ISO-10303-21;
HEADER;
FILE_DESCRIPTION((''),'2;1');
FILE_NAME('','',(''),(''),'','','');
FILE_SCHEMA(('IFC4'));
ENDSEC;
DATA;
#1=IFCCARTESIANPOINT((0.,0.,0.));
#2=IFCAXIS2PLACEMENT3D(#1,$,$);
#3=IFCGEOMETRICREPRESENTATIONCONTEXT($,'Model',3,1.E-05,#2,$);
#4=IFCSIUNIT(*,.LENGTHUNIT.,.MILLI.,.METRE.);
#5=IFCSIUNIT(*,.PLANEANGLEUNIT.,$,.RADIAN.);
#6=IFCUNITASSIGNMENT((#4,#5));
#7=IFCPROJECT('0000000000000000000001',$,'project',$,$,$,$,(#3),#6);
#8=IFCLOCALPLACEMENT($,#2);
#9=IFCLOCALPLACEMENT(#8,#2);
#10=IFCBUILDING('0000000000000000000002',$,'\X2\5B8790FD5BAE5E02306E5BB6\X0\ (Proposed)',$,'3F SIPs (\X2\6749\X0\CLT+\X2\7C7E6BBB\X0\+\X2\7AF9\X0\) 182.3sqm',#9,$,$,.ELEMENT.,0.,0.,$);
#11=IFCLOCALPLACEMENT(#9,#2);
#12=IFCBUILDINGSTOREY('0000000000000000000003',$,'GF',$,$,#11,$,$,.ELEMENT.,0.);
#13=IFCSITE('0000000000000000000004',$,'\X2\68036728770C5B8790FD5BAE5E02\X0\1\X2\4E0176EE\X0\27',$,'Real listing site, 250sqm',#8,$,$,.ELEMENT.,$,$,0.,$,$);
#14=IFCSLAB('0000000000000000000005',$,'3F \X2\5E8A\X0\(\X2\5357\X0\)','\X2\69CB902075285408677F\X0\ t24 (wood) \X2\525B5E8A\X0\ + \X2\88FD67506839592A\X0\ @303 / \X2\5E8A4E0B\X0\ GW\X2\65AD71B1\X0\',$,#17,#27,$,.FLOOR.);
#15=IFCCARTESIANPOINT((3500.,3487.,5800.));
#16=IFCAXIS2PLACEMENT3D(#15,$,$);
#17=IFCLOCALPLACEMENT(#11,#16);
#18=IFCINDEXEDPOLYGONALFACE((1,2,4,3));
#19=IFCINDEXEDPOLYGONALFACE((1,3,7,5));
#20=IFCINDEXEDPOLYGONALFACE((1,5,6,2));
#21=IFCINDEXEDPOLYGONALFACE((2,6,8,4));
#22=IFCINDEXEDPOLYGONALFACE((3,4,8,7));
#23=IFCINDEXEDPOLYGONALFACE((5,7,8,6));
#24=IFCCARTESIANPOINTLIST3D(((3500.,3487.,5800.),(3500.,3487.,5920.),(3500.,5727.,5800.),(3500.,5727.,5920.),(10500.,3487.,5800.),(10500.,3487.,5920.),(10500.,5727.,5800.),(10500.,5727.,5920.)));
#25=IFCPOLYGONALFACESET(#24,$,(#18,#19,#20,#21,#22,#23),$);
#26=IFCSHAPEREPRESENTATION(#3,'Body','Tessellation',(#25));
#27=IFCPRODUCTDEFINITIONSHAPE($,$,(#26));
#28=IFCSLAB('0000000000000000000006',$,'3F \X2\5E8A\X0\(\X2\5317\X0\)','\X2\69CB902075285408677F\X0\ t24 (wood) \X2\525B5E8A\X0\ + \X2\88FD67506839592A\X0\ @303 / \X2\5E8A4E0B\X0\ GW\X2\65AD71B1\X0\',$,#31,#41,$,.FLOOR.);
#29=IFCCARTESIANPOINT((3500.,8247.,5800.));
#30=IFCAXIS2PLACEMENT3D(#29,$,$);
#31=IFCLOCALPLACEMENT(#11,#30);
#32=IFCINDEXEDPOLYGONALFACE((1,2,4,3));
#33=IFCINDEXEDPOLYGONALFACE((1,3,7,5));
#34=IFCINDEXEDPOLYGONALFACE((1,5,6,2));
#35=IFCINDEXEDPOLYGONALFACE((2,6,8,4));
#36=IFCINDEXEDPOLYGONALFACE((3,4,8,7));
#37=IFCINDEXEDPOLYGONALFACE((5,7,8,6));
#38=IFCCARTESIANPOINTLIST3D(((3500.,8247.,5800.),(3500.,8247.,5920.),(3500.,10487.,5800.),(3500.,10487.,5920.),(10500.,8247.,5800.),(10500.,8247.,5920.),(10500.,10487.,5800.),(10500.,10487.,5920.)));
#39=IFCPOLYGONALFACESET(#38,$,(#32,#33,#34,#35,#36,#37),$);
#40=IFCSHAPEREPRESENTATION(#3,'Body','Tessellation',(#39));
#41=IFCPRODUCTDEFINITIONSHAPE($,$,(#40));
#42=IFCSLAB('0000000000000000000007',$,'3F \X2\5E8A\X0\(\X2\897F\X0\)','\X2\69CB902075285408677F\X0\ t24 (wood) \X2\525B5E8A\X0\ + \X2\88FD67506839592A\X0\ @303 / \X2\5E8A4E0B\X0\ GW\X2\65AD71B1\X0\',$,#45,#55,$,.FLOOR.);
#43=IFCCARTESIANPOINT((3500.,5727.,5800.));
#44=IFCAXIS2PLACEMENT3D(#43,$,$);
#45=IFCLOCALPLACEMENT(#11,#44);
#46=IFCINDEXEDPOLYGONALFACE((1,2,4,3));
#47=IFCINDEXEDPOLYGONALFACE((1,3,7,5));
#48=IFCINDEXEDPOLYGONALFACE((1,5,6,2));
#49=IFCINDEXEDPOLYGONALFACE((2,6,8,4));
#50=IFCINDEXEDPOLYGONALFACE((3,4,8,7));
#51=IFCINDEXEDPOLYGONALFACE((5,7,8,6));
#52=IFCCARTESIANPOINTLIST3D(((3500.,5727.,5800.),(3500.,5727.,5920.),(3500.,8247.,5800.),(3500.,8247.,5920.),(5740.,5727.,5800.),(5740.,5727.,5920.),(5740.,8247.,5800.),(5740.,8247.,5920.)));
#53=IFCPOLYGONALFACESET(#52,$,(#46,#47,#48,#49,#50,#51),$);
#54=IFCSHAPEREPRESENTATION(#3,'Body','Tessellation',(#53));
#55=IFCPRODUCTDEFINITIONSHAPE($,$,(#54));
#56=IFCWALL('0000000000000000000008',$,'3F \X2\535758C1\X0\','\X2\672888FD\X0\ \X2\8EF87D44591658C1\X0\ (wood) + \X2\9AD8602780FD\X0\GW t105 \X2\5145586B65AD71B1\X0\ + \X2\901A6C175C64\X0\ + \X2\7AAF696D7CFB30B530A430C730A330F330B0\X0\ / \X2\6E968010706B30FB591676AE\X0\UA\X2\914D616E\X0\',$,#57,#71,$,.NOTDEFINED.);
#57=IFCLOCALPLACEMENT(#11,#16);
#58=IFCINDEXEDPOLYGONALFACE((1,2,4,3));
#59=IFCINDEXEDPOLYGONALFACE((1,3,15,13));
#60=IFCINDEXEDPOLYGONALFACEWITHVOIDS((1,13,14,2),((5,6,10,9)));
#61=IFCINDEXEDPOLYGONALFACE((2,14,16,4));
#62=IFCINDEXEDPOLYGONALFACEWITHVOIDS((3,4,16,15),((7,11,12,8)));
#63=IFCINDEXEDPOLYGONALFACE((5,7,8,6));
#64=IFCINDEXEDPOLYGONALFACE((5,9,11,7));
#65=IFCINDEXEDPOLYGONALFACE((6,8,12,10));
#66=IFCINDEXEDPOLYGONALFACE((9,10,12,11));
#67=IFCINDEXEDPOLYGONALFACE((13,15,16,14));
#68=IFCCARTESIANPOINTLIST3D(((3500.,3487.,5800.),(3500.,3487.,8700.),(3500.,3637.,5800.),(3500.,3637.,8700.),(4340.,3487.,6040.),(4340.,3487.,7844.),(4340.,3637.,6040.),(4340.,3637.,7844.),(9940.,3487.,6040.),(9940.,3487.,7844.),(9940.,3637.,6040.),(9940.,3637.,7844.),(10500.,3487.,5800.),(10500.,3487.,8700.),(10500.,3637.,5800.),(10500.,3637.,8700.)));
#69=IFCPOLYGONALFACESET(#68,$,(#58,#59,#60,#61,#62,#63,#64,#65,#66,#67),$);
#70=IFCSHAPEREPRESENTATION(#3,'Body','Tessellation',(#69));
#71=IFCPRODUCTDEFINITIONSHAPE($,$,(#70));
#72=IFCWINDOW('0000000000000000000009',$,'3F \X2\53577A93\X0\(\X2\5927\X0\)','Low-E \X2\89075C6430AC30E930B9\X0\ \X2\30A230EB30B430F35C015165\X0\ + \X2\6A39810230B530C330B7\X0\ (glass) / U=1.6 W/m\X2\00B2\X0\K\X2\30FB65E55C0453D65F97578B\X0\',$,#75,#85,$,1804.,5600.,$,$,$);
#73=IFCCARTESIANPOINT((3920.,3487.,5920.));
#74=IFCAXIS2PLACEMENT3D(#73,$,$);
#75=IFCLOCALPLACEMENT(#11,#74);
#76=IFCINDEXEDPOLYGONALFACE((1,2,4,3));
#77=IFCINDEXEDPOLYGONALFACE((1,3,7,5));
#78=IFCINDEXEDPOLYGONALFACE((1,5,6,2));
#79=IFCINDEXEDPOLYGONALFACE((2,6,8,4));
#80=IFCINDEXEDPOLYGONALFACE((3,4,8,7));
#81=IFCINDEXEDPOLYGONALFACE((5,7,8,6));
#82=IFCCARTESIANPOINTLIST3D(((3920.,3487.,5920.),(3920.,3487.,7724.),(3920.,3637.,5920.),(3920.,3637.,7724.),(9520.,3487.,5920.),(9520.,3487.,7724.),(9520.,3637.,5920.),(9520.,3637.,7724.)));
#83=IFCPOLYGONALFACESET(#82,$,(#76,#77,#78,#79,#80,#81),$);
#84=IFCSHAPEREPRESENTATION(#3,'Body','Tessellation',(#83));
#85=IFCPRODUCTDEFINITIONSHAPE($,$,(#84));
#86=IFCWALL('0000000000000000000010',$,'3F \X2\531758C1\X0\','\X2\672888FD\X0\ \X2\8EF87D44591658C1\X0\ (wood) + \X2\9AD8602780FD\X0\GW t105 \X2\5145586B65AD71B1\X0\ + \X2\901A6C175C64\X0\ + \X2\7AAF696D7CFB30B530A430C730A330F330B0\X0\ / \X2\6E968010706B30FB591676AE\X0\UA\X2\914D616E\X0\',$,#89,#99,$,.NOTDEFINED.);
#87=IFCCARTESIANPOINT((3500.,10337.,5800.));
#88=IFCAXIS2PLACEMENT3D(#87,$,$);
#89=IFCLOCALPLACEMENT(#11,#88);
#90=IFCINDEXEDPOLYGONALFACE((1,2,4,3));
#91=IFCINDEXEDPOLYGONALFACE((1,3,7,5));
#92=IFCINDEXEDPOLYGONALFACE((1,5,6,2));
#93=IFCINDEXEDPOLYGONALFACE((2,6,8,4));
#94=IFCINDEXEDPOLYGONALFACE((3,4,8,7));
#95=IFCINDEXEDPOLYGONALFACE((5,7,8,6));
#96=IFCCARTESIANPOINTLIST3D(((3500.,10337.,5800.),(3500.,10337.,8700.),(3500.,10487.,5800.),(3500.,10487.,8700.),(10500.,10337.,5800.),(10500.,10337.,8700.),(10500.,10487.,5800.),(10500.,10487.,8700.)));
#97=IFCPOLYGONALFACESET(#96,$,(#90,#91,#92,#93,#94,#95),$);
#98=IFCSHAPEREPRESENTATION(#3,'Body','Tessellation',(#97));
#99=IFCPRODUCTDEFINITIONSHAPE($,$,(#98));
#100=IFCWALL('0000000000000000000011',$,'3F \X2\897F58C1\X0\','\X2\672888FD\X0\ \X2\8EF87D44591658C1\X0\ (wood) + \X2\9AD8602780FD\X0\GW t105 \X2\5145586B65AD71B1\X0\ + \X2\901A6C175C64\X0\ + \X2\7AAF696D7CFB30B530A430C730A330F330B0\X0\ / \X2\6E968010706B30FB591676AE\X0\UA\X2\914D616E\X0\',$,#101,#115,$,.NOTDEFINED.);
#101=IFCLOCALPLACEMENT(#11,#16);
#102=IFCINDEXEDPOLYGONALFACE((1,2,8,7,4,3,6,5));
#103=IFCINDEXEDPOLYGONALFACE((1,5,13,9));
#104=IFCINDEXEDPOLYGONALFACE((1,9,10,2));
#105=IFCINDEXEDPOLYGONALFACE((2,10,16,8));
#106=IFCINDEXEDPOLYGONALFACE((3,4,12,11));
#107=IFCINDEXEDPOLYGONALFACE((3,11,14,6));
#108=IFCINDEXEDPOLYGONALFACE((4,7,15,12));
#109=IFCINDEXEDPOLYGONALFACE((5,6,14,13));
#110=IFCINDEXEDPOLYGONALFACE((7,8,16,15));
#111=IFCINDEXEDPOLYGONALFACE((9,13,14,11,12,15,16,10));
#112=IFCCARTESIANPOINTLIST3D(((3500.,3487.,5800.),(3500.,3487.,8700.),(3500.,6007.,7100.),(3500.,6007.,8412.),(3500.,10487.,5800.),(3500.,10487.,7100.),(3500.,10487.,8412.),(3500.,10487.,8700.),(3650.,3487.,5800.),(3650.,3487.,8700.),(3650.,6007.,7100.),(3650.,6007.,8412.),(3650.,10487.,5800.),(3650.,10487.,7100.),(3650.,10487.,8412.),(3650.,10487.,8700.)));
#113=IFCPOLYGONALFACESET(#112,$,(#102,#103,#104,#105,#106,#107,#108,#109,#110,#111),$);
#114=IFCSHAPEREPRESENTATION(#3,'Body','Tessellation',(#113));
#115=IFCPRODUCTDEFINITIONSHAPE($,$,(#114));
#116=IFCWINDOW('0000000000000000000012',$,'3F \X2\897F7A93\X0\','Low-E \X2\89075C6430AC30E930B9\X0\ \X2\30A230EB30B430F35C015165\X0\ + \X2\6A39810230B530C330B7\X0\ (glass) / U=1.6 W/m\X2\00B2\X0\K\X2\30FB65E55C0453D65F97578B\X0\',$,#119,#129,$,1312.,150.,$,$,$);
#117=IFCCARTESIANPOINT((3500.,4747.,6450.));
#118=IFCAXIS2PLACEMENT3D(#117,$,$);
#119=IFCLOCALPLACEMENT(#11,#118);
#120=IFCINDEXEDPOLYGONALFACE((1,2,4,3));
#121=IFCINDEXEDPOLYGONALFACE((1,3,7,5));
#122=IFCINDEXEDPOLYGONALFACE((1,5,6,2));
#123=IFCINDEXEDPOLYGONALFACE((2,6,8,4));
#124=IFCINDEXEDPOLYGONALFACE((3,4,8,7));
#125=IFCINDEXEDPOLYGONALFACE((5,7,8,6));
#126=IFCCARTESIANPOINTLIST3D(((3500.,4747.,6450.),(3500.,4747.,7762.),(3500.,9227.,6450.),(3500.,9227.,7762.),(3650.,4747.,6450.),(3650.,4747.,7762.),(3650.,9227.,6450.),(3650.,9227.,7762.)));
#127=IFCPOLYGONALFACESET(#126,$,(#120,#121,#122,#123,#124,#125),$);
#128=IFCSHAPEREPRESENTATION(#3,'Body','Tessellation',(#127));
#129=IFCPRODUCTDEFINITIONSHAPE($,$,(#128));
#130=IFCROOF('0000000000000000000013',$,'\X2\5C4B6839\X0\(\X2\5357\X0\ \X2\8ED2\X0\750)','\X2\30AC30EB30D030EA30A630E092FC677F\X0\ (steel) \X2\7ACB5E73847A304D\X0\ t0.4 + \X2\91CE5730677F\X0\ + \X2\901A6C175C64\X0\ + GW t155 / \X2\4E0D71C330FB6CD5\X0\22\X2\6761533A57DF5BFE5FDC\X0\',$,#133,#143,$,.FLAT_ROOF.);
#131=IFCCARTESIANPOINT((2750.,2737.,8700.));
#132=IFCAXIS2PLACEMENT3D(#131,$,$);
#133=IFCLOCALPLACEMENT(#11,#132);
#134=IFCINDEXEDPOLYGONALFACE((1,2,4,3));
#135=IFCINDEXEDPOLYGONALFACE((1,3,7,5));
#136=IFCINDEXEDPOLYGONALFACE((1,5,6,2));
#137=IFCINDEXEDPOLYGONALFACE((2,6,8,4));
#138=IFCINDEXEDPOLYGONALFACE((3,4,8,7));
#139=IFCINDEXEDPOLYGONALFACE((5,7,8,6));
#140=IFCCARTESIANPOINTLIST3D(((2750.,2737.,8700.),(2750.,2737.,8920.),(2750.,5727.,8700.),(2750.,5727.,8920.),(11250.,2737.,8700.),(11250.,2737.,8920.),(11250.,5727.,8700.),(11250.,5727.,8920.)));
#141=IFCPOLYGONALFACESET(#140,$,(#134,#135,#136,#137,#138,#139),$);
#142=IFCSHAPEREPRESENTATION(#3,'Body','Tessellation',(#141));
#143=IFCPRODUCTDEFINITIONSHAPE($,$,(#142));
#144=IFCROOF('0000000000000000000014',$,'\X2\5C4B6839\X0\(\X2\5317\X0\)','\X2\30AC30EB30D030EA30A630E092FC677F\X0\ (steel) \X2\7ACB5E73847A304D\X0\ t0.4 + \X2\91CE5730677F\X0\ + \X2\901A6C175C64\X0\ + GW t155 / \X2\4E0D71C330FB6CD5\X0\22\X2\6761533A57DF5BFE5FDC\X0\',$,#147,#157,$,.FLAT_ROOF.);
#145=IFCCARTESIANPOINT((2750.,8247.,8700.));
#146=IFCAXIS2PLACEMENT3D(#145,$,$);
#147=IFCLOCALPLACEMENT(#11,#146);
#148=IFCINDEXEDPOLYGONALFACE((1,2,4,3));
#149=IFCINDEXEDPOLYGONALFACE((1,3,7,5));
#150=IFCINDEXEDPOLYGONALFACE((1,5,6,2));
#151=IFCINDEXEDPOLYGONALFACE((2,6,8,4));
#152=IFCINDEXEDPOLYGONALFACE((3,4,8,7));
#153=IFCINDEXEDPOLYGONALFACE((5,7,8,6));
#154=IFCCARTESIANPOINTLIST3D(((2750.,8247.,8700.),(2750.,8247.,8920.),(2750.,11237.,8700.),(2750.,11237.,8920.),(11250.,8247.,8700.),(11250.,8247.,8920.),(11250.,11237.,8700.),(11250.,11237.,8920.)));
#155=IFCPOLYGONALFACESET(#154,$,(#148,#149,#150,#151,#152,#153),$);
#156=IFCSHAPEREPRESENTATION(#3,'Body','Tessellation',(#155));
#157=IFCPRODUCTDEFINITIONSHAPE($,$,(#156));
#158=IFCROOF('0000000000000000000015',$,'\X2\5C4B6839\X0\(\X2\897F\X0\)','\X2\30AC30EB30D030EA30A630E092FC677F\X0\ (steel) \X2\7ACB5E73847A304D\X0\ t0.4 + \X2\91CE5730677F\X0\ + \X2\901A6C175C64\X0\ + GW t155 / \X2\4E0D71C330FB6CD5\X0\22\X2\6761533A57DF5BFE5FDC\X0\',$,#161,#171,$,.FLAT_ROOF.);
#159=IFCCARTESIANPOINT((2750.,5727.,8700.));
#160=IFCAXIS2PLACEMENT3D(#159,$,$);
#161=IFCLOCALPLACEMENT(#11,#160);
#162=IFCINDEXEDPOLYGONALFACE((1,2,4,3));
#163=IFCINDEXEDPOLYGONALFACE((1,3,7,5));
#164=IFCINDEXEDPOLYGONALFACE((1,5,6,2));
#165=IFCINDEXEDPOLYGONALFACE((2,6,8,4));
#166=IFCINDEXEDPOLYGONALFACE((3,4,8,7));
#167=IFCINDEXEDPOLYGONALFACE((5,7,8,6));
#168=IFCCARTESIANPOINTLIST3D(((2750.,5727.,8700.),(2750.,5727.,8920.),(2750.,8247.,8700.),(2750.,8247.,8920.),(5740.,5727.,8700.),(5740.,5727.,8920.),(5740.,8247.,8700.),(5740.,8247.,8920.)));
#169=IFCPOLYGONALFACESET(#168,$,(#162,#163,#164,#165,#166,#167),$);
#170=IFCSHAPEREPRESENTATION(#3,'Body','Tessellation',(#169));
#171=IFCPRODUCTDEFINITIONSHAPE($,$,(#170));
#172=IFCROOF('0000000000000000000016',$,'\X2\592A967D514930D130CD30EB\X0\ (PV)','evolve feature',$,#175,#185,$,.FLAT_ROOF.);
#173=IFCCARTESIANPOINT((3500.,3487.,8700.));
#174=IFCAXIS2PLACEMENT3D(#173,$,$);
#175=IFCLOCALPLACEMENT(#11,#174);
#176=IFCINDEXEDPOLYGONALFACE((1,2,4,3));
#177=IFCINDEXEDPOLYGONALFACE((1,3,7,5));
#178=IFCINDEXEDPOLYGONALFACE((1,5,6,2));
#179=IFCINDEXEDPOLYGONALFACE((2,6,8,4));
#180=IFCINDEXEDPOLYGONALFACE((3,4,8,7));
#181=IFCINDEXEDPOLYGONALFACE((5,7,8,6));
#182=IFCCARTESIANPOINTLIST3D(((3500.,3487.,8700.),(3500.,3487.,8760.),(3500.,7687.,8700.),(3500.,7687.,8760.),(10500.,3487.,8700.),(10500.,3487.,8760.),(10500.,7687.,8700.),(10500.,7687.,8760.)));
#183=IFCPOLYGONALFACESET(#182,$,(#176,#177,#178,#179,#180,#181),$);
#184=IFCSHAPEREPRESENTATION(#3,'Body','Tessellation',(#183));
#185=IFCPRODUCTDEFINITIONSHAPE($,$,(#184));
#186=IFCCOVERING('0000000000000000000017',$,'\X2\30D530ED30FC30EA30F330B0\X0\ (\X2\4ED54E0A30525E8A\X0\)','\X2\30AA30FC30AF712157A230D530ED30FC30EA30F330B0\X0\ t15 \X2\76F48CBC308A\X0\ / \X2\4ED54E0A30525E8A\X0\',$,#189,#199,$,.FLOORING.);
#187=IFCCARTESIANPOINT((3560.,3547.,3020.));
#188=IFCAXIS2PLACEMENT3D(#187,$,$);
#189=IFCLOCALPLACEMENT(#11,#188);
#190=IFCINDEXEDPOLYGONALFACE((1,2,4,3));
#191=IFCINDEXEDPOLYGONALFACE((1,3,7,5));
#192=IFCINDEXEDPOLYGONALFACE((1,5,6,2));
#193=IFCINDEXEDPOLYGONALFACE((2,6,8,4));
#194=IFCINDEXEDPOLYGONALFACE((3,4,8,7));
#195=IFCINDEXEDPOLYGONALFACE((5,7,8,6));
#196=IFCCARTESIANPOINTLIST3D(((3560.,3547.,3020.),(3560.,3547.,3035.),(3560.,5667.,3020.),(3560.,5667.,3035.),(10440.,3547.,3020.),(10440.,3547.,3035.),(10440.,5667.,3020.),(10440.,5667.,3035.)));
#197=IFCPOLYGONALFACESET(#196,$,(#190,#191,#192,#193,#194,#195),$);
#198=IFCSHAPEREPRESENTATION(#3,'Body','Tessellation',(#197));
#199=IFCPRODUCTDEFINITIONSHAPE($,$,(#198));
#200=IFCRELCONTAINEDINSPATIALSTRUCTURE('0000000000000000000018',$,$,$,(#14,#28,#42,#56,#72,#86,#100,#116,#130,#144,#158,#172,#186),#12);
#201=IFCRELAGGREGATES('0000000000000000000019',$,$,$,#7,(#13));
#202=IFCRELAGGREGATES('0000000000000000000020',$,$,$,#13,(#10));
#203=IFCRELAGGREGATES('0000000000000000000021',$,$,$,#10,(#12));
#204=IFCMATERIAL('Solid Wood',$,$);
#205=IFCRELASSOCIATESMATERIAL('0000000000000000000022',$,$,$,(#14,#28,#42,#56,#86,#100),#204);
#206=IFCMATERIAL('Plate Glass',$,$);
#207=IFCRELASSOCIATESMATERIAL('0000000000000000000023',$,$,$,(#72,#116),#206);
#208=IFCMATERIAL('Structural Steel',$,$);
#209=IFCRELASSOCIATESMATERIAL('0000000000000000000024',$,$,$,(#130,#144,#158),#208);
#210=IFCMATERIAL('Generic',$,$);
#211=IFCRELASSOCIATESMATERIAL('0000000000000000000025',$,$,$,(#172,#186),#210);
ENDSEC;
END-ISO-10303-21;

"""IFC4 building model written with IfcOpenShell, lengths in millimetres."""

from ifc_helpers import new_model, si_unit, frame, frame_2d, origin, place, context, project, spatial, rectangle, extrude, material, element, fill, save


model = new_model("IFC4")

# Units and contexts
model_context = context("Model", 3, precision=1e-05, world=origin())
ifc_project = project(units=[si_unit("LENGTHUNIT", "METRE", prefix="MILLI"), si_unit("PLANEANGLEUNIT", "RADIAN")], contexts=[model_context])

# Site, building, storey
site_placement = place(None, origin())
site = spatial("IfcSite", under=ifc_project, at=site_placement, Name="栃木県宇都宮市1丁目27", ObjectType="Real listing site, 250sqm", CompositionType="ELEMENT", RefElevation=0.0)
building_placement = place(site_placement, origin())
building = spatial("IfcBuilding", under=site, at=building_placement, Name="宇都宮市の家 (Proposed)", ObjectType="3F SIPs (杉CLT+籾殻+竹) 182.3sqm", CompositionType="ELEMENT", ElevationOfRefHeight=0.0, ElevationOfTerrain=0.0)
storey_placement = place(building_placement, origin())
storey = spatial("IfcBuildingStorey", under=building, at=storey_placement, Name="GF", CompositionType="ELEMENT", Elevation=0.0)

# Slabs
ifc_material_1 = material(Name="Solid Wood")
slab_1_placement = place(storey_placement, frame((3500.0, 3487.0, 5800.0)))
element("IfcSlab", 1, at=slab_1_placement, inside=storey, material=ifc_material_1, Name="3F 床(南)", Description="構造用合板 t24 (wood) 剛床 + 製材根太 @303 / 床下 GW断熱", PredefinedType="FLOOR", context=model_context, shape_type="SweptSolid", body=[
    extrude(rectangle(XDim=7000.0, YDim=2240.0, at=frame_2d((3500.0, 1120.0))), frame((3500.0, 3487.0, 5800.0)), (0.0, 0.0, 1.0), 120.0),
])
slab_2_placement = place(storey_placement, frame((3500.0, 8247.0, 5800.0)))
element("IfcSlab", 2, at=slab_2_placement, inside=storey, material=ifc_material_1, Name="3F 床(北)", Description="構造用合板 t24 (wood) 剛床 + 製材根太 @303 / 床下 GW断熱", PredefinedType="FLOOR", context=model_context, shape_type="SweptSolid", body=[
    extrude(rectangle(XDim=7000.0, YDim=2240.0, at=frame_2d((3500.0, 1120.0))), frame((3500.0, 8247.0, 5800.0)), (0.0, 0.0, 1.0), 120.0),
])
slab_3_placement = place(storey_placement, frame((3500.0, 5727.0, 5800.0)))
element("IfcSlab", 3, at=slab_3_placement, inside=storey, material=ifc_material_1, Name="3F 床(西)", Description="構造用合板 t24 (wood) 剛床 + 製材根太 @303 / 床下 GW断熱", PredefinedType="FLOOR", context=model_context, shape_type="SweptSolid", body=[
    extrude(rectangle(XDim=2240.0, YDim=2520.0, at=frame_2d((1120.0, 1260.0))), frame((3500.0, 5727.0, 5800.0)), (0.0, 0.0, 1.0), 120.0),
])

# Wall, opening, window
wall_1_placement = place(storey_placement, frame((3500.0, 3487.0, 5800.0)))
wall_1 = element("IfcWall", 4, at=wall_1_placement, inside=storey, material=ifc_material_1, Name="3F 南壁", Description="木製 軸組外壁 (wood) + 高性能GW t105 充填断熱 + 通気層 + 窯業系サイディング / 準耐火・外皮UA配慮", PredefinedType="NOTDEFINED", context=model_context, shape_type="SweptSolid", body=[
    extrude(rectangle(XDim=7000.0, YDim=150.0, at=frame_2d((3500.0, 75.0))), frame((3500.0, 3487.0, 5800.0)), (0.0, 0.0, 1.0), 2900.0),
])
opening_1_placement = place(storey_placement, frame((3920.0, 3487.0, 5920.0)))
opening_1 = element("IfcOpeningElement", 5, at=opening_1_placement, cuts=wall_1, PredefinedType="NOTDEFINED", context=model_context, shape_type="SweptSolid", body=[
    extrude(rectangle(XDim=5600.0, YDim=150.0, at=frame_2d((2800.0, 75.0))), frame((3920.0, 3487.0, 5920.0)), (0.0, 0.0, 1.0), 1804.0),
])
ifc_material_2 = material(Name="Plate Glass")
window_1_placement = place(storey_placement, frame((3920.0, 3487.0, 5920.0)))
window_1 = element("IfcWindow", 6, at=window_1_placement, inside=storey, material=ifc_material_2, Name="3F 南窓(大)", Description="Low-E 複層ガラス アルゴン封入 + 樹脂サッシ (glass) / U=1.6 W/m²K・日射取得型", OverallHeight=1804.0, OverallWidth=5600.0, context=model_context, shape_type="SweptSolid", body=[
    extrude(rectangle(XDim=5600.0, YDim=150.0, at=frame_2d((2800.0, 75.0))), frame((3920.0, 3487.0, 5920.0)), (0.0, 0.0, 1.0), 1804.0),
])
fill(opening_1, window_1)

# Wall
wall_2_placement = place(storey_placement, frame((3500.0, 10337.0, 5800.0)))
element("IfcWall", 7, at=wall_2_placement, inside=storey, material=ifc_material_1, Name="3F 北壁", Description="木製 軸組外壁 (wood) + 高性能GW t105 充填断熱 + 通気層 + 窯業系サイディング / 準耐火・外皮UA配慮", PredefinedType="NOTDEFINED", context=model_context, shape_type="SweptSolid", body=[
    extrude(rectangle(XDim=7000.0, YDim=150.0, at=frame_2d((3500.0, 75.0))), frame((3500.0, 10337.0, 5800.0)), (0.0, 0.0, 1.0), 2900.0),
])

# Wall, opening, window
wall_3_placement = place(storey_placement, frame((3500.0, 3487.0, 5800.0)))
wall_3 = element("IfcWall", 8, at=wall_3_placement, inside=storey, material=ifc_material_1, Name="3F 西壁", Description="木製 軸組外壁 (wood) + 高性能GW t105 充填断熱 + 通気層 + 窯業系サイディング / 準耐火・外皮UA配慮", PredefinedType="NOTDEFINED", context=model_context, shape_type="SweptSolid", body=[
    extrude(rectangle(XDim=150.0, YDim=7000.0, at=frame_2d((75.0, 3500.0))), frame((3500.0, 3487.0, 5800.0)), (0.0, 0.0, 1.0), 2900.0),
])
opening_2_placement = place(storey_placement, frame((3500.0, 4747.0, 6450.0)))
opening_2 = element("IfcOpeningElement", 9, at=opening_2_placement, cuts=wall_3, PredefinedType="NOTDEFINED", context=model_context, shape_type="SweptSolid", body=[
    extrude(rectangle(XDim=150.0, YDim=4480.0, at=frame_2d((75.0, 2240.0))), frame((3500.0, 4747.0, 6450.0)), (0.0, 0.0, 1.0), 1312.0),
])
window_2_placement = place(storey_placement, frame((3500.0, 4747.0, 6450.0)))
window_2 = element("IfcWindow", 10, at=window_2_placement, inside=storey, material=ifc_material_2, Name="3F 西窓", Description="Low-E 複層ガラス アルゴン封入 + 樹脂サッシ (glass) / U=1.6 W/m²K・日射取得型", OverallHeight=1312.0, OverallWidth=150.0, context=model_context, shape_type="SweptSolid", body=[
    extrude(rectangle(XDim=150.0, YDim=4480.0, at=frame_2d((75.0, 2240.0))), frame((3500.0, 4747.0, 6450.0)), (0.0, 0.0, 1.0), 1312.0),
])
fill(opening_2, window_2)

# Roofs
ifc_material_3 = material(Name="Structural Steel")
roof_1_placement = place(storey_placement, frame((2750.0, 2737.0, 8700.0)))
element("IfcRoof", 11, at=roof_1_placement, inside=storey, material=ifc_material_3, Name="屋根(南 軒750)", Description="ガルバリウム鋼板 (steel) 立平葺き t0.4 + 野地板 + 通気層 + GW t155 / 不燃・法22条区域対応", PredefinedType="FLAT_ROOF", context=model_context, shape_type="SweptSolid", body=[
    extrude(rectangle(XDim=8500.0, YDim=2990.0, at=frame_2d((4250.0, 1495.0))), frame((2750.0, 2737.0, 8700.0)), (0.0, 0.0, 1.0), 220.0),
])
roof_2_placement = place(storey_placement, frame((2750.0, 8247.0, 8700.0)))
element("IfcRoof", 12, at=roof_2_placement, inside=storey, material=ifc_material_3, Name="屋根(北)", Description="ガルバリウム鋼板 (steel) 立平葺き t0.4 + 野地板 + 通気層 + GW t155 / 不燃・法22条区域対応", PredefinedType="FLAT_ROOF", context=model_context, shape_type="SweptSolid", body=[
    extrude(rectangle(XDim=8500.0, YDim=2990.0, at=frame_2d((4250.0, 1495.0))), frame((2750.0, 8247.0, 8700.0)), (0.0, 0.0, 1.0), 220.0),
])
roof_3_placement = place(storey_placement, frame((2750.0, 5727.0, 8700.0)))
element("IfcRoof", 13, at=roof_3_placement, inside=storey, material=ifc_material_3, Name="屋根(西)", Description="ガルバリウム鋼板 (steel) 立平葺き t0.4 + 野地板 + 通気層 + GW t155 / 不燃・法22条区域対応", PredefinedType="FLAT_ROOF", context=model_context, shape_type="SweptSolid", body=[
    extrude(rectangle(XDim=2990.0, YDim=2520.0, at=frame_2d((1495.0, 1260.0))), frame((2750.0, 5727.0, 8700.0)), (0.0, 0.0, 1.0), 220.0),
])
ifc_material_4 = material(Name="Generic")
roof_4_placement = place(storey_placement, frame((3500.0, 3487.0, 8700.0)))
element("IfcRoof", 14, at=roof_4_placement, inside=storey, material=ifc_material_4, Name="太陽光パネル (PV)", Description="evolve feature", PredefinedType="FLAT_ROOF", context=model_context, shape_type="SweptSolid", body=[
    extrude(rectangle(XDim=7000.0, YDim=4200.0, at=frame_2d((3500.0, 2100.0))), frame((3500.0, 3487.0, 8700.0)), (0.0, 0.0, 1.0), 60.0),
])

# Covering
covering_1_placement = place(storey_placement, frame((3560.0, 3547.0, 3020.0)))
element("IfcCovering", 15, at=covering_1_placement, inside=storey, material=ifc_material_4, Name="フローリング (仕上げ床)", Description="オーク無垢フローリング t15 直貼り / 仕上げ床", PredefinedType="FLOORING", context=model_context, shape_type="SweptSolid", body=[
    extrude(rectangle(XDim=6880.0, YDim=2120.0, at=frame_2d((3440.0, 1060.0))), frame((3560.0, 3547.0, 3020.0)), (0.0, 0.0, 1.0), 15.0),
])

save(model, "model.ifc")
